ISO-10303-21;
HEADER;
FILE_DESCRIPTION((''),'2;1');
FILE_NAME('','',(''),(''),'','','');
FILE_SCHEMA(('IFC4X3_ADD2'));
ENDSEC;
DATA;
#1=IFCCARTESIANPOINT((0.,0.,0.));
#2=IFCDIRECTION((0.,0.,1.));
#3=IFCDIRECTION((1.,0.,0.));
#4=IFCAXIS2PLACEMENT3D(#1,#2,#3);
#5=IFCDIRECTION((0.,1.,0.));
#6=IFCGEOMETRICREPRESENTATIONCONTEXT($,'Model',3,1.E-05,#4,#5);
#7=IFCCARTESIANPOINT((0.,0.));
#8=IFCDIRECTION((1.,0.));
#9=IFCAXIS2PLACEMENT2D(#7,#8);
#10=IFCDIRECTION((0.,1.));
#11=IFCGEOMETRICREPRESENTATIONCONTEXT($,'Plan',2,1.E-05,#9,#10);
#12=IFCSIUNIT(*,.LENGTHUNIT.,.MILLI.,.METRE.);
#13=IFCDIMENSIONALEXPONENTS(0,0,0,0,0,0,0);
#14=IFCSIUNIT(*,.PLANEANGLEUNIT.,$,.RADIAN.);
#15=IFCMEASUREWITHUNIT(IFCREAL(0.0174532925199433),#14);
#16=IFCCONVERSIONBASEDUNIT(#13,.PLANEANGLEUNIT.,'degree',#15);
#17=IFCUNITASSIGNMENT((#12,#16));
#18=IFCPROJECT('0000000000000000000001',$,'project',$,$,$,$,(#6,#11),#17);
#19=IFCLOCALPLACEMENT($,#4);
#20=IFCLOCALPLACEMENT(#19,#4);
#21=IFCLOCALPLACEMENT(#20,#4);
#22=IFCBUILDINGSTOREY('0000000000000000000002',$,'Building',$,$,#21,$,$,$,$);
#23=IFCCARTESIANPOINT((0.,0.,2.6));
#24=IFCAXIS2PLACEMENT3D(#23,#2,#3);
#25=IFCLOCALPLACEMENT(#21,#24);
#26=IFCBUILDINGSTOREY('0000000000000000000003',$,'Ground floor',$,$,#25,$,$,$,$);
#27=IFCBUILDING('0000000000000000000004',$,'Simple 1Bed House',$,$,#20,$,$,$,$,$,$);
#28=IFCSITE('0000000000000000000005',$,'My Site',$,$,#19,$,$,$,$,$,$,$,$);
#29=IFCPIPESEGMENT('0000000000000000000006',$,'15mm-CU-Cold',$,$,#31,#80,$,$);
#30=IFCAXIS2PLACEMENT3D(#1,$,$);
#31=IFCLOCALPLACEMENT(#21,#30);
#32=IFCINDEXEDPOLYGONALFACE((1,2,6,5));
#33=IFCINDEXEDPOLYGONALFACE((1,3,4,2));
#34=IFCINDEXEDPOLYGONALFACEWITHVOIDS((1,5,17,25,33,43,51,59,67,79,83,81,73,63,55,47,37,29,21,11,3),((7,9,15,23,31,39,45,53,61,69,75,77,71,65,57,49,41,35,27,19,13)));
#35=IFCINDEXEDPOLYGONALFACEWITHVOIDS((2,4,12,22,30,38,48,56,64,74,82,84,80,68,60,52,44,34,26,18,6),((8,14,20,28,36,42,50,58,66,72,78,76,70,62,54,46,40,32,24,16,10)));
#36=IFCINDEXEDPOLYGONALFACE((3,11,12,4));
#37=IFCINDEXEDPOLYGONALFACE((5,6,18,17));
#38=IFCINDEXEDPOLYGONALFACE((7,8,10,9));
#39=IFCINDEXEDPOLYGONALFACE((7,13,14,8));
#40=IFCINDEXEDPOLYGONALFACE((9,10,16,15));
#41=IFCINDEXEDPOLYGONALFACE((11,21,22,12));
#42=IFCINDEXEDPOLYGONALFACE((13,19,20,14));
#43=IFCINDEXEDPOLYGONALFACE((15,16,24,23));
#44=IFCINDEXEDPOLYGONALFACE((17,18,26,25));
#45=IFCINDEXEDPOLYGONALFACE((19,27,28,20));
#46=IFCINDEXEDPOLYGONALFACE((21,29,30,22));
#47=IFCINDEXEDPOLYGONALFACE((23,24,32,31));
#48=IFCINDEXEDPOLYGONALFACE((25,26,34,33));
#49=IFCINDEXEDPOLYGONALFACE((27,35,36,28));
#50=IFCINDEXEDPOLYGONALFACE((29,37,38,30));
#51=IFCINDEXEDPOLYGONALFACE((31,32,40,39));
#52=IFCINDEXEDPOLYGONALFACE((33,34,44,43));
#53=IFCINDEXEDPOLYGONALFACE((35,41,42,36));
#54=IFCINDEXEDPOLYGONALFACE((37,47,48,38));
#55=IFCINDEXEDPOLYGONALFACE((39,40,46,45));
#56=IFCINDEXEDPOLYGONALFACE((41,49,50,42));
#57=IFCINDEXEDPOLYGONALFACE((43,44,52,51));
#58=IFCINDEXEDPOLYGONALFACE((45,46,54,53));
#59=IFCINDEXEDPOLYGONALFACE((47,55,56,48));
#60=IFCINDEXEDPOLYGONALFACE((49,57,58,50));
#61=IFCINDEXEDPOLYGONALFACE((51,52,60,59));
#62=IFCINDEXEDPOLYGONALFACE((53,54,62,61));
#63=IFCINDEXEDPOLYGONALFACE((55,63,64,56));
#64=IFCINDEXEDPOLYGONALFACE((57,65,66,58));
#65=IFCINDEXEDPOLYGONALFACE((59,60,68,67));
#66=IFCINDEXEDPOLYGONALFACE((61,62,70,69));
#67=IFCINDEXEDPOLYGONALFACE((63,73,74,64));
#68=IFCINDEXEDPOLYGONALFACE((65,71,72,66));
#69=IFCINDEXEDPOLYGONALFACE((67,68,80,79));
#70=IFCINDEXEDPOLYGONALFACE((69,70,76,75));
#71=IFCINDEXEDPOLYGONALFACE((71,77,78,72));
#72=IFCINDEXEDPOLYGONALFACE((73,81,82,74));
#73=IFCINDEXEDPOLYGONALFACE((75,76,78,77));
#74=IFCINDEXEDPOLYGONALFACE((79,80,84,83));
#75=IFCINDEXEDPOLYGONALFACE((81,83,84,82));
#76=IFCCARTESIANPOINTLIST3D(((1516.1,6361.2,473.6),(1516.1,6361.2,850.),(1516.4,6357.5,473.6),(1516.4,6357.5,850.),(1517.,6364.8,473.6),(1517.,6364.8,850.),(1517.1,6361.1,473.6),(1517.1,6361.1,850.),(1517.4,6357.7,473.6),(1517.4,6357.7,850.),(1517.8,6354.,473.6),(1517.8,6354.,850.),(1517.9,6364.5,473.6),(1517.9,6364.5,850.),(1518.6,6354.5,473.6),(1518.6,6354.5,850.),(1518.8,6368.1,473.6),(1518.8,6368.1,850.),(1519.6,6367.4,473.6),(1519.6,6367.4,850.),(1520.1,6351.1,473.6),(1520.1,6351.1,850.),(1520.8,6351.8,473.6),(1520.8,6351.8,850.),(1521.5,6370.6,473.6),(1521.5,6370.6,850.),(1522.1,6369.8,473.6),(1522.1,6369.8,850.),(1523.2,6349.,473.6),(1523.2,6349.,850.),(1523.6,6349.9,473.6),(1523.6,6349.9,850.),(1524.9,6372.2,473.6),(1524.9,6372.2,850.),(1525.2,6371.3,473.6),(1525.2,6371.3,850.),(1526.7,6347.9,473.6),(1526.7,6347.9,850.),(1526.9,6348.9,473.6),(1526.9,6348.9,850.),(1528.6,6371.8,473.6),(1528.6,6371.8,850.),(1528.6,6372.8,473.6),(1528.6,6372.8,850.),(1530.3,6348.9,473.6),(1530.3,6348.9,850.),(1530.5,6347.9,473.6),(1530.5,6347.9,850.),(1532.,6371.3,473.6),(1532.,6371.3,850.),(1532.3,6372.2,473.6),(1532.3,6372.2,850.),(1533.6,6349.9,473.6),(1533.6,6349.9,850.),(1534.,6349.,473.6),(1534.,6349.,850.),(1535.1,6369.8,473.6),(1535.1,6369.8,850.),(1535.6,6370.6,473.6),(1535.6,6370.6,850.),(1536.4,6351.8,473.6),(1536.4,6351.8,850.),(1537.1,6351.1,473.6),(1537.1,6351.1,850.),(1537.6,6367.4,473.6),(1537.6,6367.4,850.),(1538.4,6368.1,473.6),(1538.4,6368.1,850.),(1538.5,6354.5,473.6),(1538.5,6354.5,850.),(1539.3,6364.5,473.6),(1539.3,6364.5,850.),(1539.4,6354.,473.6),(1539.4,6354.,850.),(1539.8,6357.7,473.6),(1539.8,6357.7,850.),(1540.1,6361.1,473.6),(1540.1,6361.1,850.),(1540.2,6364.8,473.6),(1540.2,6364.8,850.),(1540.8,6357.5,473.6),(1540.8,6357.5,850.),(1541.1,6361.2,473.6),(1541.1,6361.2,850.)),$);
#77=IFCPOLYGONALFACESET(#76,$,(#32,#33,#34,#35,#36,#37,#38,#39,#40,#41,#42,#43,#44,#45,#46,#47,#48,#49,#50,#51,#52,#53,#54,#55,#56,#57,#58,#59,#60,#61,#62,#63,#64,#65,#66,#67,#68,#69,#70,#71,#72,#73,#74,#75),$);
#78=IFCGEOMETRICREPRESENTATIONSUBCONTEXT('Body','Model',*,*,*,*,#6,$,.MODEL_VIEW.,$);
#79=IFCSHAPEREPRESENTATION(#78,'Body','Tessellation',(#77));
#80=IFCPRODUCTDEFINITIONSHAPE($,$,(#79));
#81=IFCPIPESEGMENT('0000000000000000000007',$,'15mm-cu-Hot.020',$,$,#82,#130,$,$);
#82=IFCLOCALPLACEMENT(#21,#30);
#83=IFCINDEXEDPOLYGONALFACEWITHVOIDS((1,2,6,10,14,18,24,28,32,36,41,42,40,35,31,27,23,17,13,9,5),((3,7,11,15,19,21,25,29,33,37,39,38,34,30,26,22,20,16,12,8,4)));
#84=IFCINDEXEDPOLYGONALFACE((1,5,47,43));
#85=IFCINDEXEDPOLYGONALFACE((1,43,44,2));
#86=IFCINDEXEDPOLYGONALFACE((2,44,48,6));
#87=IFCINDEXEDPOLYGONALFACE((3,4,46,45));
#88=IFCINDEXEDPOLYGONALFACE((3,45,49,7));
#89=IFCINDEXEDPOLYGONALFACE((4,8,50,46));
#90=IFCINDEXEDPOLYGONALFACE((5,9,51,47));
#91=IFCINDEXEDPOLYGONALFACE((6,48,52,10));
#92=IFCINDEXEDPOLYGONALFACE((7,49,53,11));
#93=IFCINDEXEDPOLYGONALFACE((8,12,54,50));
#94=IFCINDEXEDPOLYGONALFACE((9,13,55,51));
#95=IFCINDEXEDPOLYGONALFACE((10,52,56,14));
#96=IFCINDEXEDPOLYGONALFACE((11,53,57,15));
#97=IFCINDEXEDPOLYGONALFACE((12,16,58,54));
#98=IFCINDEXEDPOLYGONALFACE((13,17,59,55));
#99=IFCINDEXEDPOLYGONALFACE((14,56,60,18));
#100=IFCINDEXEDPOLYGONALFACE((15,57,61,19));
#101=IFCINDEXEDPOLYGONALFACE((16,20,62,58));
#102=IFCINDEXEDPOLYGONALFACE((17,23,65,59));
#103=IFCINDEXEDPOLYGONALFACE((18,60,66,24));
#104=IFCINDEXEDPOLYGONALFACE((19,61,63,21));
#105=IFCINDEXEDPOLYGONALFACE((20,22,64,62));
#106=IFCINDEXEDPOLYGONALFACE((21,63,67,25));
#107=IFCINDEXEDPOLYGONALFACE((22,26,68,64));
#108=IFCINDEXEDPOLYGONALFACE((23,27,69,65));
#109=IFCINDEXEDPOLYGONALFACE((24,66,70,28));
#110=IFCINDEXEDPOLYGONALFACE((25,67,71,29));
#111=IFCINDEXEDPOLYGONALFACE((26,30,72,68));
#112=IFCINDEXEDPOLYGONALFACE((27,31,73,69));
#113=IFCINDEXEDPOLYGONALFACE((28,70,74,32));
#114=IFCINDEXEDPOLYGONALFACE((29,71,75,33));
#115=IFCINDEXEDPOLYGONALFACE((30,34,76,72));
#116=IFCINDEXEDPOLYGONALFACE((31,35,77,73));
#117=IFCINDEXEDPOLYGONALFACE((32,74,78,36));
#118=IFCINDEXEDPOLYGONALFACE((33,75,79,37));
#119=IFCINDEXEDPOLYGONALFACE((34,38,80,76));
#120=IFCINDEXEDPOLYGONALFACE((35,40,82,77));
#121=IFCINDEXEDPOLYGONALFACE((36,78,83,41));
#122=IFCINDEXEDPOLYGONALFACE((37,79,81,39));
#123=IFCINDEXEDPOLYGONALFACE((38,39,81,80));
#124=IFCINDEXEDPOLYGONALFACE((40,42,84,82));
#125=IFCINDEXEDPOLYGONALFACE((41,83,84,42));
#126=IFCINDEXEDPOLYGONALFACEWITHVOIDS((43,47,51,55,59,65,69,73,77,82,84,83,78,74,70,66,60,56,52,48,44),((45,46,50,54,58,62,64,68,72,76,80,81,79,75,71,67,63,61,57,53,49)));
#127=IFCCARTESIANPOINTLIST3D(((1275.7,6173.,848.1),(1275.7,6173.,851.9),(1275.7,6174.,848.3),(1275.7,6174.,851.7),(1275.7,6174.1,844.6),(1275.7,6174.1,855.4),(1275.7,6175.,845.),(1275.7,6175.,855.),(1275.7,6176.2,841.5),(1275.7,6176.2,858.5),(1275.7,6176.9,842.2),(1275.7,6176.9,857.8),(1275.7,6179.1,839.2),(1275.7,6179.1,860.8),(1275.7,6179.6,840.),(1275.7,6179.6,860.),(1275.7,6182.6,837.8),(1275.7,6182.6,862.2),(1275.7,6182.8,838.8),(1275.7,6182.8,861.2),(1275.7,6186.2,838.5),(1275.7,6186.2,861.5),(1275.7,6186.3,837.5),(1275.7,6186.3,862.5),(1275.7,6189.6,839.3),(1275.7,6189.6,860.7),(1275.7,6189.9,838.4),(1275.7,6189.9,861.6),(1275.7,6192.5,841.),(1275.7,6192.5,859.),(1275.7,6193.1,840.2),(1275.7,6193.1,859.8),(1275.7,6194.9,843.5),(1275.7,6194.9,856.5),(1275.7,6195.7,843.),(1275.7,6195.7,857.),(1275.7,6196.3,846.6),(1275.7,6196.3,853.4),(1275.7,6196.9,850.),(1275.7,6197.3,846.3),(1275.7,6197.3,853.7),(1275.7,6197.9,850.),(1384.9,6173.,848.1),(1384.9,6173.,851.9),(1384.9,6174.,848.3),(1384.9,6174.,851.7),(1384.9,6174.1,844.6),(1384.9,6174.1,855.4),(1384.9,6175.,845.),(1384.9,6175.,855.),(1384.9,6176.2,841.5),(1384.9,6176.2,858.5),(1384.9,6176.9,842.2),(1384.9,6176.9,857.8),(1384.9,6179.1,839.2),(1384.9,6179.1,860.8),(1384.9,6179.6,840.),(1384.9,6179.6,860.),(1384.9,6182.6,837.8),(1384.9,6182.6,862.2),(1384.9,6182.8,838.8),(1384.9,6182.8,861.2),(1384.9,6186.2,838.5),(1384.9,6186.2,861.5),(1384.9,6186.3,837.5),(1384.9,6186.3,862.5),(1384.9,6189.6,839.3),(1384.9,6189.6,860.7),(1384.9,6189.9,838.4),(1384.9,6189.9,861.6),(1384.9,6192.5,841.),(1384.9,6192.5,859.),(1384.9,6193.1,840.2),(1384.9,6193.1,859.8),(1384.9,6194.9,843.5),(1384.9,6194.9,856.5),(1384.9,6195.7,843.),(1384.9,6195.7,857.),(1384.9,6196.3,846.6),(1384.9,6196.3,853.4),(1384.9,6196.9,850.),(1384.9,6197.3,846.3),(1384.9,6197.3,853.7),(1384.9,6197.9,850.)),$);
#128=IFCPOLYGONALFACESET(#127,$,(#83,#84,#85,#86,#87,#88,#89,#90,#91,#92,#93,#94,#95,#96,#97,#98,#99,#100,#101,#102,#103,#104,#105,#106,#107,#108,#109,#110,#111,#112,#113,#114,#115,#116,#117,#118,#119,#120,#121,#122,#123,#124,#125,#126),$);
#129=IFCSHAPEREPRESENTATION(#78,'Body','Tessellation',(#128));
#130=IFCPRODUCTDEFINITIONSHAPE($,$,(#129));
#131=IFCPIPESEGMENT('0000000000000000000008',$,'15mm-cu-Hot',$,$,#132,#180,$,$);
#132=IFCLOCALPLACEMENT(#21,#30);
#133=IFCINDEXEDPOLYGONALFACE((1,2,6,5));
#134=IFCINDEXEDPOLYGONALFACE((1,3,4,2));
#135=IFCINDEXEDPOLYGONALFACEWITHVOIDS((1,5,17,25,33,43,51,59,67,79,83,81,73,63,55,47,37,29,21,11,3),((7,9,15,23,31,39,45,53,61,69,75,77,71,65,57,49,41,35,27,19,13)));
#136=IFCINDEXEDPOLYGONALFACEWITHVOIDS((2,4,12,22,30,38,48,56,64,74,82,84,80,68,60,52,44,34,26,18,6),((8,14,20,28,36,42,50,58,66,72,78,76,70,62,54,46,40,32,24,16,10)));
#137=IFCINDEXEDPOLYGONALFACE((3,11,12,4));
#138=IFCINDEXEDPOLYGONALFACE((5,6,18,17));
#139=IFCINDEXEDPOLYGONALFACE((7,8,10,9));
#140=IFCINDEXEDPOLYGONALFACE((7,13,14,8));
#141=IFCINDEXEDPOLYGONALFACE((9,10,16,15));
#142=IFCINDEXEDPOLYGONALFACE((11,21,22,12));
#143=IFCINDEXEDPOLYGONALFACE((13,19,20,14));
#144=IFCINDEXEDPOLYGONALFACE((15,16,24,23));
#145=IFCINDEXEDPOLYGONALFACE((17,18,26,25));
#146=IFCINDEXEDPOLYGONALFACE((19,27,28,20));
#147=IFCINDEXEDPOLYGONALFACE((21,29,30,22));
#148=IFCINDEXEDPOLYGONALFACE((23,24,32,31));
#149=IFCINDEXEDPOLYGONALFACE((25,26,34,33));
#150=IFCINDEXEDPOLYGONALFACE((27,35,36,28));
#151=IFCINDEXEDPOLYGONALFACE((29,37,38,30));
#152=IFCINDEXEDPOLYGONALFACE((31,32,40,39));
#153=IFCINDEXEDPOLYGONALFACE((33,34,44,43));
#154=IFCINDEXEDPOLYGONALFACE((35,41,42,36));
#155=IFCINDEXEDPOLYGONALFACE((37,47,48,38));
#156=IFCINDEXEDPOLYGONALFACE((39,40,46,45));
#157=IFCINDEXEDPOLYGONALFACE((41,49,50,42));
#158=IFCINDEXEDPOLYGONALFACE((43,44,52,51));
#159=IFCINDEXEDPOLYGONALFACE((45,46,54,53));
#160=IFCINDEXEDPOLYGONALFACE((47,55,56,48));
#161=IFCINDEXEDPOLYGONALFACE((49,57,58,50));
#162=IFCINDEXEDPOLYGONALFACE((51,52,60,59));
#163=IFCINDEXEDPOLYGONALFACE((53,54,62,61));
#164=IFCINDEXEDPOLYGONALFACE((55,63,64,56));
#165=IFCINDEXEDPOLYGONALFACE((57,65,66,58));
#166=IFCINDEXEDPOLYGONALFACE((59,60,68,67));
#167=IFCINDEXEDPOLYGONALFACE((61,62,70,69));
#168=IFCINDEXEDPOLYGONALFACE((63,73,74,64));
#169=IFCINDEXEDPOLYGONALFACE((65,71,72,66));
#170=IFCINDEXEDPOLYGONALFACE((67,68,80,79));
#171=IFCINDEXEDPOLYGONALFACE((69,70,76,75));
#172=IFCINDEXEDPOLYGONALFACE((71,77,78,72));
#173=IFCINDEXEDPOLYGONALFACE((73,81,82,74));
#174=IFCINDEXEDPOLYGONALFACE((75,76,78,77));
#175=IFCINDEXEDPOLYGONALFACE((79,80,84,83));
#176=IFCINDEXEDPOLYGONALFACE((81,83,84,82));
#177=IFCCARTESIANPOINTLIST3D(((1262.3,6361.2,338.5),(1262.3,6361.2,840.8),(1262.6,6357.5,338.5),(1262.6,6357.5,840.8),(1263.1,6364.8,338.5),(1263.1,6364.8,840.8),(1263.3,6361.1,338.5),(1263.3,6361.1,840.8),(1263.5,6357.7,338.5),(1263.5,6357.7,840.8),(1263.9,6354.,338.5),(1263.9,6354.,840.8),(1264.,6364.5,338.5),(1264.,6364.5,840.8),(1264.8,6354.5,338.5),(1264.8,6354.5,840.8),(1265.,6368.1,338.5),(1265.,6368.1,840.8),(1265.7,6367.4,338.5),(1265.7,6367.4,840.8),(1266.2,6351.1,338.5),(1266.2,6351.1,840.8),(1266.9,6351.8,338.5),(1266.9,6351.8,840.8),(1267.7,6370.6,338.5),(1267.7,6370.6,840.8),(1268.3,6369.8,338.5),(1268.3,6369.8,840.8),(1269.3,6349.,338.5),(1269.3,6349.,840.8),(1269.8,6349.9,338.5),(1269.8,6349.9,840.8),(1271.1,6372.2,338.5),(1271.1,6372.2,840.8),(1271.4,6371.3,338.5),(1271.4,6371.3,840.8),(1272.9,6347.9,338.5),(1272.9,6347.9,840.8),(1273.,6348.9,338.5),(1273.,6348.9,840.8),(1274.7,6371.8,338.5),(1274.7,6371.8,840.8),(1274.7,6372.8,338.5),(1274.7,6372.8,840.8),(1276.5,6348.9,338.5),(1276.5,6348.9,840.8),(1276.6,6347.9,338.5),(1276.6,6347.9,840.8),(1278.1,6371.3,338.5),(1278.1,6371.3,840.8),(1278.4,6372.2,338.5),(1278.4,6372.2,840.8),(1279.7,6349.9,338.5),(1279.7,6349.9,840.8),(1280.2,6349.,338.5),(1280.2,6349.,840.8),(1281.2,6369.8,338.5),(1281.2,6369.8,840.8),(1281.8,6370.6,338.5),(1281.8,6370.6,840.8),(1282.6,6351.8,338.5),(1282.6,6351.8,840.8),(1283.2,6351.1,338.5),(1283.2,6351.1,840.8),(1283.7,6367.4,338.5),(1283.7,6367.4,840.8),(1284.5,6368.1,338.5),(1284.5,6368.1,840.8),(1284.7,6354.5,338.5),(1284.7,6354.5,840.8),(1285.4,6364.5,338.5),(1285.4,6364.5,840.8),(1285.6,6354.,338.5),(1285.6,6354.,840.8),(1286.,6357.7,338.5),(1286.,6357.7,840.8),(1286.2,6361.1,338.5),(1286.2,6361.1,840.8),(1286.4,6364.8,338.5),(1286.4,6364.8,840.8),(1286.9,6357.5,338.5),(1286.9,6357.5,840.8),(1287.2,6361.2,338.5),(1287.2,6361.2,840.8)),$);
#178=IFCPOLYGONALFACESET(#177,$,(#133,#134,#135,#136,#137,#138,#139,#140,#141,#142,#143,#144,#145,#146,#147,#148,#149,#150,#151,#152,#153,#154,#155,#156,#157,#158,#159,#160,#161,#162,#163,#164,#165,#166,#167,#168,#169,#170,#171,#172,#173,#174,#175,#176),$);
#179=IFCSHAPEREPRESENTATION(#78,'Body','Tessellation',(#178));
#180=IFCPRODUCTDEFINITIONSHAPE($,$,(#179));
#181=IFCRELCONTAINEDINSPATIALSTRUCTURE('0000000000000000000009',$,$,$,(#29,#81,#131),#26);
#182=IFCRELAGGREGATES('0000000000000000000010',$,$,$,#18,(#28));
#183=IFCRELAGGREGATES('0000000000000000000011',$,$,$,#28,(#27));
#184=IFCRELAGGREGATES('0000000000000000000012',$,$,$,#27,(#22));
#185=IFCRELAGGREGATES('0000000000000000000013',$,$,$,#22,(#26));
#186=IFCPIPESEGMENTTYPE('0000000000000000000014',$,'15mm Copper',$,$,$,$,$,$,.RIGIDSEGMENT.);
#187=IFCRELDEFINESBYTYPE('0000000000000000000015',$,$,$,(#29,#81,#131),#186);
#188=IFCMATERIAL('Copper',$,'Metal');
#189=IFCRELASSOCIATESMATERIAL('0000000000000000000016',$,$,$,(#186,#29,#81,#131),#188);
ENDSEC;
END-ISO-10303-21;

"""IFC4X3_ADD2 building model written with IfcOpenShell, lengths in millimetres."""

from ifc_helpers import new_model, entity, si_unit, converted_unit, direction, frame, origin_with_axes, origin_2d_with_axis, place, context, subcontext, project, spatial, hollow_circle, extrude, material, material_profile, profile_set, profile_usage, type_object, element, save


model = new_model("IFC4X3_ADD2")

# Units and contexts
model_context = context("Model", 3, precision=1e-05, world=origin_with_axes(), true_north=direction((0.0, 1.0, 0.0)))
plan_context = context("Plan", 2, precision=1e-05, world=origin_2d_with_axis(), true_north=direction((0.0, 1.0)))
body_context_1 = subcontext(model_context, "Body", "Model", "MODEL_VIEW")
ifc_project = project(units=[si_unit("LENGTHUNIT", "METRE", prefix="MILLI"), converted_unit("PLANEANGLEUNIT", "degree", entity("IfcReal", 0.0174532925199433), si_unit("PLANEANGLEUNIT", "RADIAN"), dimensions=[0, 0, 0, 0, 0, 0, 0])], contexts=[model_context, plan_context])

# Site, building, storeys
site_placement = place(None, origin_with_axes())
site = spatial("IfcSite", under=ifc_project, at=site_placement, Name="My Site")
building_placement = place(site_placement, origin_with_axes())
building = spatial("IfcBuilding", under=site, at=building_placement, Name="Simple 1Bed House")
storey_1_placement = place(building_placement, origin_with_axes())
storey_1 = spatial("IfcBuildingStorey", under=building, at=storey_1_placement, Name="Building")
storey_2_placement = place(storey_1_placement, frame((0.0, 0.0, 2.6), z_axis=(0.0, 0.0, 1.0), x_axis=(1.0, 0.0, 0.0)))
storey_2 = spatial("IfcBuildingStorey", under=storey_1, at=storey_2_placement, Name="Ground floor")

# Pipe segments
ifc_material_1 = material(Name="Copper", Category="Metal")
ifc_material_profile_1 = material_profile(ifc_material_1, hollow_circle(Radius=12.5, WallThickness=1.0))
ifc_profile_set_1 = profile_set([ifc_material_profile_1])
pipe_segment_type_1 = type_object("IfcPipeSegmentType", Name="15mm Copper", PredefinedType="RIGIDSEGMENT", material=ifc_profile_set_1)
ifc_profile_usage_1 = profile_usage(ifc_profile_set_1, cardinal=5)
pipe_segment_1_placement = place(storey_2_placement, frame((1528.6, 6360.3, 847.4), z_axis=(0.0, 0.0, -1.0), x_axis=(0.0, 1.0, 0.0)))
element("IfcPipeSegment", 1, at=pipe_segment_1_placement, inside=storey_2, type_object=pipe_segment_type_1, material=ifc_profile_usage_1, Name="15mm-CU-Cold", context=body_context_1, shape_type="SweptSolid", body=[
    extrude(hollow_circle(Radius=12.5, WallThickness=1.0), origin_with_axes(), (0.0, 0.0, 1.0), 376.4),
])
ifc_profile_usage_2 = profile_usage(ifc_profile_set_1, cardinal=5)
pipe_segment_2_placement = place(storey_2_placement, frame((1384.9, 6185.4, 847.4), z_axis=(-1.0, 0.0, 0.0), x_axis=(0.0, 1.0, 0.0)))
element("IfcPipeSegment", 2, at=pipe_segment_2_placement, inside=storey_2, type_object=pipe_segment_type_1, material=ifc_profile_usage_2, Name="15mm-cu-Hot.020", context=body_context_1, shape_type="SweptSolid", body=[
    extrude(hollow_circle(Radius=12.5, WallThickness=1.0), origin_with_axes(), (0.0, 0.0, 1.0), 109.1),
])
ifc_profile_usage_3 = profile_usage(ifc_profile_set_1, cardinal=5)
pipe_segment_3_placement = place(storey_2_placement, frame((1274.7, 6360.3, 838.2), z_axis=(0.0, 0.0, -1.0), x_axis=(0.0, 1.0, 0.0)))
element("IfcPipeSegment", 3, at=pipe_segment_3_placement, inside=storey_2, type_object=pipe_segment_type_1, material=ifc_profile_usage_3, Name="15mm-cu-Hot", context=body_context_1, shape_type="SweptSolid", body=[
    extrude(hollow_circle(Radius=12.5, WallThickness=1.0), origin_with_axes(), (0.0, 0.0, 1.0), 502.2),
])

save(model, "model.ifc")
